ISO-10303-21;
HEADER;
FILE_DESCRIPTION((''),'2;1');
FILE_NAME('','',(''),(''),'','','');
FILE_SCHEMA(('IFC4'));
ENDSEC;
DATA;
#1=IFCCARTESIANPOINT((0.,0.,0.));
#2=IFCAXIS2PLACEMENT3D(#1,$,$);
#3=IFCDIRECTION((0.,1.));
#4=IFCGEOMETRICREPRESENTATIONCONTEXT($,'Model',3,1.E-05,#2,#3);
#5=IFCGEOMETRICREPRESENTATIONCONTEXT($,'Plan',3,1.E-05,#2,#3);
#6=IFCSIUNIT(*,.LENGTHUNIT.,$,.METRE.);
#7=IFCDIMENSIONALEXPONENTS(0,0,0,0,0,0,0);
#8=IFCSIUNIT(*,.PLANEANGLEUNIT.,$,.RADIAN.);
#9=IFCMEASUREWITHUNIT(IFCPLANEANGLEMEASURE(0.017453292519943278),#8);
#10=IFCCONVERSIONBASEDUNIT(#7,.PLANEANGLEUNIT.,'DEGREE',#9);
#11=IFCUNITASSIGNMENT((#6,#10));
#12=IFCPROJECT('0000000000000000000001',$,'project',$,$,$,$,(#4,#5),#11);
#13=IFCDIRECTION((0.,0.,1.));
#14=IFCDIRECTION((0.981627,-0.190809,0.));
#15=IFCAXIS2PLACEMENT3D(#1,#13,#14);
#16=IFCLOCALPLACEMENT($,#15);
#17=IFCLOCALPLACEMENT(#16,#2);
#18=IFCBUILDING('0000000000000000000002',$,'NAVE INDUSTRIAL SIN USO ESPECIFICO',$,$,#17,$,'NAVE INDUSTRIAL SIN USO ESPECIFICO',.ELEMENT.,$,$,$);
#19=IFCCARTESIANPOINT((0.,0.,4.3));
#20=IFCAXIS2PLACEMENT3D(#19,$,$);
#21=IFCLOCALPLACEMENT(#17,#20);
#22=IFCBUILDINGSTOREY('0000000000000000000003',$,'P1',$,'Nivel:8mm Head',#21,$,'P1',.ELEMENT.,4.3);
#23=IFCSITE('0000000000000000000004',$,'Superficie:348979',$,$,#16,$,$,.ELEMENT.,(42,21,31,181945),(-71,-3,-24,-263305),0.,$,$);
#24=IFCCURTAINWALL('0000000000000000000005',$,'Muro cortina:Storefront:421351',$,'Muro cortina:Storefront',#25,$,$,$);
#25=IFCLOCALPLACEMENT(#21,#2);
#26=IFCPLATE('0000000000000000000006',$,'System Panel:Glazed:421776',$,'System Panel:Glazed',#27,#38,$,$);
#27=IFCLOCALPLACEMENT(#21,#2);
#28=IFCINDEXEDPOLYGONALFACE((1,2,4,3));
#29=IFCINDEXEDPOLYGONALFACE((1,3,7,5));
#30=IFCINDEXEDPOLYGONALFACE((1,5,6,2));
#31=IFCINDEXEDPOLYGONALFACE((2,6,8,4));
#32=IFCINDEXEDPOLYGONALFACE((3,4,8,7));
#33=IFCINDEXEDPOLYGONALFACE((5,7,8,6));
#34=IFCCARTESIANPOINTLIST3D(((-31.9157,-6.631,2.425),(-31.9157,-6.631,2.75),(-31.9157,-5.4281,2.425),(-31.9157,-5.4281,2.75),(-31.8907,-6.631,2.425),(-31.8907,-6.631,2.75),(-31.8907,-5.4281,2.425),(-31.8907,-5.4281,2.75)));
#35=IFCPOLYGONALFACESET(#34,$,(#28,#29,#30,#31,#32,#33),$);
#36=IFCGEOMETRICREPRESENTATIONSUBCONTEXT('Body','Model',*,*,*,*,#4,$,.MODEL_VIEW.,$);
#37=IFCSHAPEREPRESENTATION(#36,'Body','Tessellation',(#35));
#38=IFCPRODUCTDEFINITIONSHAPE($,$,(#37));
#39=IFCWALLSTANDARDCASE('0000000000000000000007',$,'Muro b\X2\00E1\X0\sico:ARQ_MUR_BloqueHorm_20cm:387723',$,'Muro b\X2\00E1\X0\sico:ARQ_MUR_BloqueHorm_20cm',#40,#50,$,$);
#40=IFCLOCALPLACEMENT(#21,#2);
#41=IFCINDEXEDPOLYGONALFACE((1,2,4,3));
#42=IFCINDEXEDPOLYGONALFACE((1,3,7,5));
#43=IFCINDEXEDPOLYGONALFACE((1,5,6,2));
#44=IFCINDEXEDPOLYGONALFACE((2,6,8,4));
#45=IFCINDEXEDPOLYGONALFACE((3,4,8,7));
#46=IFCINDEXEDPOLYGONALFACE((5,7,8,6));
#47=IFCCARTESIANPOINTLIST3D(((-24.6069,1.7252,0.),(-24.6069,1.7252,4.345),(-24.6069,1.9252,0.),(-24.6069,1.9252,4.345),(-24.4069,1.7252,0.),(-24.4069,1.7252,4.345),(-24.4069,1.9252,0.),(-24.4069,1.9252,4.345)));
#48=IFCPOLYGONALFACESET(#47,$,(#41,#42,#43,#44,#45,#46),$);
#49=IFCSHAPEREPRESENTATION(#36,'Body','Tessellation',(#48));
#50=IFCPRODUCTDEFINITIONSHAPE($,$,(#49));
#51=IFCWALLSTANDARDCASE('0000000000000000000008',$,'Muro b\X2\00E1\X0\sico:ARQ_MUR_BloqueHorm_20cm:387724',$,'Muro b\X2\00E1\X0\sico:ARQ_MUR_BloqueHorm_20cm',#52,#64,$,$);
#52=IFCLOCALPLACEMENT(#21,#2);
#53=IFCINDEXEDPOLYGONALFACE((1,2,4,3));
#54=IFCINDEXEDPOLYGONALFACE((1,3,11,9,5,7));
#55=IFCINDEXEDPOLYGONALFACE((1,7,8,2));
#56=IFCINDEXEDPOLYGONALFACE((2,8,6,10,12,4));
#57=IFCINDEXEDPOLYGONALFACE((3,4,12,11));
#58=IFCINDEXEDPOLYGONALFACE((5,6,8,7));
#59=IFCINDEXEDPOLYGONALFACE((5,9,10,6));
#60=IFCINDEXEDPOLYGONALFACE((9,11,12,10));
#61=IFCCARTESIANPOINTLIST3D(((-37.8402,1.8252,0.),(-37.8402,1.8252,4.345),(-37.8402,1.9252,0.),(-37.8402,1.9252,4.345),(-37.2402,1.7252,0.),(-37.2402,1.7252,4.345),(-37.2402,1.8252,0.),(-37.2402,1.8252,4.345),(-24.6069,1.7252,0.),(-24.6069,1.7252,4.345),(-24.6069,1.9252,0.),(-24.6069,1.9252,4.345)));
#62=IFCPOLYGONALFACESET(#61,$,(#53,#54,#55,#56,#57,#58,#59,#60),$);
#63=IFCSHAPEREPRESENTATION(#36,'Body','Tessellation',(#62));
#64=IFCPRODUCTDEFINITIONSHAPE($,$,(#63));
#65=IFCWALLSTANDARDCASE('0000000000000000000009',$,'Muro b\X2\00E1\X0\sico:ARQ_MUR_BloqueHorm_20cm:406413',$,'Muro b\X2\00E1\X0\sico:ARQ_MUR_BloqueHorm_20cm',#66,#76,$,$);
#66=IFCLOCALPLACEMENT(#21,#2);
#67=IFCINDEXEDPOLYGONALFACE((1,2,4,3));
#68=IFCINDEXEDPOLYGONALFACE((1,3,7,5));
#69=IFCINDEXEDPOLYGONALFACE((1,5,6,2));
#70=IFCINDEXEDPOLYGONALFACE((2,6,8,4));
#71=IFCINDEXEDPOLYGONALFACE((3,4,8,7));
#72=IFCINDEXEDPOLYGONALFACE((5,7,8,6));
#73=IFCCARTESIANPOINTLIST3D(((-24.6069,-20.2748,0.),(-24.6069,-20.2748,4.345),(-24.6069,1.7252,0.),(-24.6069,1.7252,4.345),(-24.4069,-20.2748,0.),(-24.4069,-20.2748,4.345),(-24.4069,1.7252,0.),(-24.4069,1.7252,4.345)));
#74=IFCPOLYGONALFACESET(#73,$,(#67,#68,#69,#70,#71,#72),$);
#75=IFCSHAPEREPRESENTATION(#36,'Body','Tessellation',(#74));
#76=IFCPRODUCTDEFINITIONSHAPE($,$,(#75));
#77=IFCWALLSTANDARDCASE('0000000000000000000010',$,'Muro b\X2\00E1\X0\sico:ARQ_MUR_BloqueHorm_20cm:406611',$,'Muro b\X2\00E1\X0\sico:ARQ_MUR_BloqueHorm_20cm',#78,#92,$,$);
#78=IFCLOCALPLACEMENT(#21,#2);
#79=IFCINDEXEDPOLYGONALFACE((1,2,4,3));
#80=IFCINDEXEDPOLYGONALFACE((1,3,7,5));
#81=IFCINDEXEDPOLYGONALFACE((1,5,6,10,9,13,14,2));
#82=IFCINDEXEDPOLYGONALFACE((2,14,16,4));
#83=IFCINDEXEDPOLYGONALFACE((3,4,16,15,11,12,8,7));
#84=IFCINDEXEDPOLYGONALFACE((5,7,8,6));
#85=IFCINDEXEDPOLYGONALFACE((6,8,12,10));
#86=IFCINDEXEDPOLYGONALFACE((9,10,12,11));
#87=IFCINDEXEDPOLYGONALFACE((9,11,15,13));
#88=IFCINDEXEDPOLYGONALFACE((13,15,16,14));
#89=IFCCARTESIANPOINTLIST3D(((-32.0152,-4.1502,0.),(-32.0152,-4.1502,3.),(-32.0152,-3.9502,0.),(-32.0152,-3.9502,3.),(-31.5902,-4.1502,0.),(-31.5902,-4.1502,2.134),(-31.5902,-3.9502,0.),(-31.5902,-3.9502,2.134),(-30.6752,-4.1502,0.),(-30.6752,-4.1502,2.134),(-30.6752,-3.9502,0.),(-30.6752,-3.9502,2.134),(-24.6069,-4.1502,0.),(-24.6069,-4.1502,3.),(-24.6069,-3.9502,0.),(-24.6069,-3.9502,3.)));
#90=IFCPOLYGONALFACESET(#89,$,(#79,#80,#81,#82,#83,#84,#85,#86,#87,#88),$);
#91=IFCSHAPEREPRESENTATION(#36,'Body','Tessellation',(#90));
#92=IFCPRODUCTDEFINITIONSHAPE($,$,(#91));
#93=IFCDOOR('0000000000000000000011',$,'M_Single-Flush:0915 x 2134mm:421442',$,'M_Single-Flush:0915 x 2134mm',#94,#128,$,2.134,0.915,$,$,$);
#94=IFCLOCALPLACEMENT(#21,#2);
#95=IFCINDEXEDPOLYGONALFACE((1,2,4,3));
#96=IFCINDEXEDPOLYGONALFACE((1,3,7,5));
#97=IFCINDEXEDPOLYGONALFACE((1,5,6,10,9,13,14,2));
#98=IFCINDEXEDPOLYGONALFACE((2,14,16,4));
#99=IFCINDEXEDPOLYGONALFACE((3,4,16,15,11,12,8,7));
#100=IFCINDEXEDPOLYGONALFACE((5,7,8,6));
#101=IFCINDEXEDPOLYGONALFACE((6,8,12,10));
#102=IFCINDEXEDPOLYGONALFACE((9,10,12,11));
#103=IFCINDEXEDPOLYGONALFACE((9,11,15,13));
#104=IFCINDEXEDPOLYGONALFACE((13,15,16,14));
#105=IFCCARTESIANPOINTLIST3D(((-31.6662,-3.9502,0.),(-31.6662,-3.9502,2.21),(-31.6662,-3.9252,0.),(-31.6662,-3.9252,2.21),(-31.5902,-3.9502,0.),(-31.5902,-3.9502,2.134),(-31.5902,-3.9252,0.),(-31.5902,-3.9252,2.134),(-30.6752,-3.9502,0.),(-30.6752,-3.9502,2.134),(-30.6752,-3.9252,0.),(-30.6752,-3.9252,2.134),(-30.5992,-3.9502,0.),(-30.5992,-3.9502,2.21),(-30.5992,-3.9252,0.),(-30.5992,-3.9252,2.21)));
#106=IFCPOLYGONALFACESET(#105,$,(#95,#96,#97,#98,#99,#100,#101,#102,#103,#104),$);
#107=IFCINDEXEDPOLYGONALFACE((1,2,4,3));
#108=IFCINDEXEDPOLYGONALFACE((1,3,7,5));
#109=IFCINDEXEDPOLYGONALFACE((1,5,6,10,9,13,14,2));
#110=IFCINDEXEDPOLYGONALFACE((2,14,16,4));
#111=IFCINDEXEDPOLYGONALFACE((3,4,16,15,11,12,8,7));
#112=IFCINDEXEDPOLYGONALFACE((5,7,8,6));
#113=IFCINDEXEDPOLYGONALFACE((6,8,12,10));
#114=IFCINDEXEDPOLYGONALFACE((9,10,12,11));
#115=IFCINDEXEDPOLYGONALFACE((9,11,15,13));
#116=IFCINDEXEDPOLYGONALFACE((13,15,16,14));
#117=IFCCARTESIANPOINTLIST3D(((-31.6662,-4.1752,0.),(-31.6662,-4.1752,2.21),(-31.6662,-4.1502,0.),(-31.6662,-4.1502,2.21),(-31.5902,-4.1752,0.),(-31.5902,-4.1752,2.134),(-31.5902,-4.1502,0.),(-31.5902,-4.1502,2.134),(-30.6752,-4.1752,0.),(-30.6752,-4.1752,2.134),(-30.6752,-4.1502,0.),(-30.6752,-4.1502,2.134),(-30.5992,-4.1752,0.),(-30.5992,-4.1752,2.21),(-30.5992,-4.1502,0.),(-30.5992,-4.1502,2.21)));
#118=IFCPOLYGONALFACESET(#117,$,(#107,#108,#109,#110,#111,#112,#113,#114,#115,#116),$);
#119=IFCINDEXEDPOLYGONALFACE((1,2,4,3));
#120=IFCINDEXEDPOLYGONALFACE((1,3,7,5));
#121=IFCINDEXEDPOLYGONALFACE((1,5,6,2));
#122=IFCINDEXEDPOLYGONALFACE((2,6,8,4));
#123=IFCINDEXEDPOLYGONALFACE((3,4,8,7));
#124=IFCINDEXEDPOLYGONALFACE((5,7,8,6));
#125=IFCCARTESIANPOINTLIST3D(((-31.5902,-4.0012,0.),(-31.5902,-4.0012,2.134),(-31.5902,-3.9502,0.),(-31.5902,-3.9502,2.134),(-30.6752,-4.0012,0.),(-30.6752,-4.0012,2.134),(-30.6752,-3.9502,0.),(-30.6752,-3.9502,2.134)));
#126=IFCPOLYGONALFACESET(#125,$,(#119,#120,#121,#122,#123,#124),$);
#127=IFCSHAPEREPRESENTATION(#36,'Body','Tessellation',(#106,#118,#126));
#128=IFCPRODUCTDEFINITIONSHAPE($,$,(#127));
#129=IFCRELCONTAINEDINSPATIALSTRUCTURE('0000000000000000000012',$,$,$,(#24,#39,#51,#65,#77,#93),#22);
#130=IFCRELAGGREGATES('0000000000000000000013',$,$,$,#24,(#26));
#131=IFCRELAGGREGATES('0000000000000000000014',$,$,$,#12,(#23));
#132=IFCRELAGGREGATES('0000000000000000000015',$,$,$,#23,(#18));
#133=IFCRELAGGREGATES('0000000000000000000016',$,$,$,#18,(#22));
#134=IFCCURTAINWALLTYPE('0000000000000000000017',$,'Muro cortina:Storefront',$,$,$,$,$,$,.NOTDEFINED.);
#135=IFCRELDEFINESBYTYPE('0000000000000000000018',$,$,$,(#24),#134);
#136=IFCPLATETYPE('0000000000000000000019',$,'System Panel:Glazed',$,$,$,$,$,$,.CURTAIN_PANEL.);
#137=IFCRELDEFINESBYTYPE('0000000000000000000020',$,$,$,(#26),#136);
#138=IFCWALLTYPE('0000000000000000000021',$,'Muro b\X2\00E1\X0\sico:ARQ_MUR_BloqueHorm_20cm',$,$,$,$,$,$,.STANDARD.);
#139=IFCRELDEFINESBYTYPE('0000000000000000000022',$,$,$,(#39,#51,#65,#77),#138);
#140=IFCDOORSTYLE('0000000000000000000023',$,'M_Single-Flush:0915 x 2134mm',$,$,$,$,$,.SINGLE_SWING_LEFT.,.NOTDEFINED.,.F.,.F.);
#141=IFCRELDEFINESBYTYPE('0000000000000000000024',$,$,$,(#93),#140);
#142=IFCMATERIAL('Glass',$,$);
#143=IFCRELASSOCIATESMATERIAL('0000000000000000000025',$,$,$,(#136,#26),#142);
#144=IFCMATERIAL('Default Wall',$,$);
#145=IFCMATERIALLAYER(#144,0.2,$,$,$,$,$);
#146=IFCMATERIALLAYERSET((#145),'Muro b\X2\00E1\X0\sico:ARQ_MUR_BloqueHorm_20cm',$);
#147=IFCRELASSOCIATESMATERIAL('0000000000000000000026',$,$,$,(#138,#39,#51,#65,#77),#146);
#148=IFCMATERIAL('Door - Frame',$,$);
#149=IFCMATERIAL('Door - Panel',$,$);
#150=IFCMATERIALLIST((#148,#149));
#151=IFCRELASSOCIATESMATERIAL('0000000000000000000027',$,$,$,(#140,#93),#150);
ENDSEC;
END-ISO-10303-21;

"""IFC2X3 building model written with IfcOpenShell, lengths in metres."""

from ifc_helpers import new_model, entity, si_unit, converted_unit, direction, frame, frame_2d, origin, origin_2d_with_axis, place, context, subcontext, project, spatial, polyline, rectangle, outline, extrude, clip, bounded_halfspace, source, transform, mapped, material, material_list, layer, layer_set, layer_usage, type_object, type_shapes, element, fill, aggregate, save


model = new_model("IFC2X3")

# Units and contexts
model_context = context("Model", 3, precision=1e-05, world=origin(), true_north=direction((0.0, 1.0)))
plan_context = context("Plan", 3, precision=1e-05, world=origin(), true_north=direction((0.0, 1.0)))
body_context = subcontext(model_context, "Body", "Model", "MODEL_VIEW")
ifc_project = project(units=[si_unit("LENGTHUNIT", "METRE"), converted_unit("PLANEANGLEUNIT", "DEGREE", entity("IfcPlaneAngleMeasure", 0.017453292519943278), si_unit("PLANEANGLEUNIT", "RADIAN"), dimensions=[0, 0, 0, 0, 0, 0, 0])], contexts=[model_context, plan_context])

# Site, building, storey
site_placement = place(None, frame((0.0, 0.0, 0.0), z_axis=(0.0, 0.0, 1.0), x_axis=(0.981627, -0.190809, 0.0)))
site = spatial("IfcSite", under=ifc_project, at=site_placement, Name="Superficie:348979", CompositionType="ELEMENT", RefLatitude=(42, 21, 31, 181945), RefLongitude=(-71, -3, -24, -263305), RefElevation=0.0)
building_placement = place(site_placement, origin())
building = spatial("IfcBuilding", under=site, at=building_placement, Name="NAVE INDUSTRIAL SIN USO ESPECIFICO", LongName="NAVE INDUSTRIAL SIN USO ESPECIFICO", CompositionType="ELEMENT")
storey_placement = place(building_placement, frame((0.0, 0.0, 4.3)))
storey = spatial("IfcBuildingStorey", under=building, at=storey_placement, Name="P1", ObjectType="Nivel:8mm Head", LongName="P1", CompositionType="ELEMENT", Elevation=4.3)

# Curtain wall
curtain_wall_type = type_object("IfcCurtainWallType", Name="Muro cortina:Storefront", PredefinedType="NOTDEFINED")
curtain_wall_placement = place(storey_placement, frame((0.0, 0.0, -4.3)))
curtain_wall = element("IfcCurtainWall", 1, at=curtain_wall_placement, inside=storey, type_object=curtain_wall_type, Name="Muro cortina:Storefront:421351", ObjectType="Muro cortina:Storefront")

# Plate
ifc_material_1 = material(Name="Glass")
plate_type_1 = type_object("IfcPlateType", Name="System Panel:Glazed", PredefinedType="CURTAIN_PANEL", material=ifc_material_1)
shared_shape_1 = source(origin(), body_context, "Body", "SweptSolid", [
    extrude(rectangle(XDim=0.025, YDim=1.2029, at=origin_2d_with_axis()), frame((0.6014, 0.0125, 0.0), z_axis=(0.0, 0.0, 1.0), x_axis=(0.0, 1.0, 0.0)), (0.0, 0.0, 1.0), 0.325),
])
type_shapes(plate_type_1, [shared_shape_1])
plate_1_placement = place(curtain_wall_placement, frame((-31.9157, -5.4281, 6.725), z_axis=(0.0, 0.0, 1.0), x_axis=(0.0, -1.0, 0.0)))
plate_1 = element("IfcPlate", 2, at=plate_1_placement, type_object=plate_type_1, material=ifc_material_1, Name="System Panel:Glazed:421776", ObjectType="System Panel:Glazed", context=body_context, shape_type="MappedRepresentation", body=[
    mapped(shared_shape_1, transform((0.0, 0.0, 0.0), scale=1.0)),
])
aggregate(curtain_wall, [plate_1])

# Walls
ifc_material_2 = material(Name="Default Wall")
ifc_layer_1 = layer(ifc_material_2, 0.2)
ifc_layer_set_1 = layer_set([ifc_layer_1], Name="Muro básico:ARQ_MUR_BloqueHorm_20cm")
ifc_layer_usage_1 = layer_usage(ifc_layer_set_1, "AXIS2", "POSITIVE", -0.1)
wall_type_1 = type_object("IfcWallType", Name="Muro básico:ARQ_MUR_BloqueHorm_20cm", PredefinedType="STANDARD", material=ifc_layer_set_1)
wall_1_placement = place(storey_placement, frame((-24.5069, 1.7252, 0.0), z_axis=(0.0, 0.0, 1.0), x_axis=(0.0, 1.0, 0.0)))
element("IfcWallStandardCase", 3, at=wall_1_placement, inside=storey, type_object=wall_type_1, material=ifc_layer_usage_1, Name="Muro básico:ARQ_MUR_BloqueHorm_20cm:387723", ObjectType="Muro básico:ARQ_MUR_BloqueHorm_20cm", context=body_context, shape_type="Clipping", body=[
    clip(extrude(rectangle(XDim=0.2, YDim=0.2, at=frame_2d((0.1, 0.0), x_axis=(0.0, -1.0))), origin(), (0.0, 0.0, 1.0), 4.345), bounded_halfspace(frame((0.0, -0.1, 0.0), z_axis=(-1.0, 0.0, 0.0), x_axis=(0.0, -1.0, 0.0)), False, frame((0.0, -0.1, 0.0), z_axis=(-1.0, 0.0, 0.0), x_axis=(0.0, -1.0, 0.0)), polyline([(0.0, 0.0), (0.0, 4.345), (-0.2, 4.345), (-0.2, 0.0), (0.0, 0.0)]))),
])
ifc_layer_usage_2 = layer_usage(ifc_layer_set_1, "AXIS2", "POSITIVE", -0.1)
wall_2_placement = place(storey_placement, frame((-24.6069, 1.8252, 0.0), z_axis=(0.0, 0.0, 1.0), x_axis=(-1.0, 0.0, 0.0)))
element("IfcWallStandardCase", 4, at=wall_2_placement, inside=storey, type_object=wall_type_1, material=ifc_layer_usage_2, Name="Muro básico:ARQ_MUR_BloqueHorm_20cm:387724", ObjectType="Muro básico:ARQ_MUR_BloqueHorm_20cm", context=body_context, shape_type="Clipping", body=[
    clip(clip(extrude(rectangle(XDim=13.2333, YDim=0.2, at=frame_2d((6.6167, 0.0), x_axis=(-1.0, 0.0))), origin(), (0.0, 0.0, 1.0), 4.345), bounded_halfspace(frame((12.6333, 0.0, 0.0), z_axis=(0.0, -1.0, 0.0), x_axis=(0.0, 0.0, -1.0)), True, frame((12.6333, 0.0, 0.0), z_axis=(0.0, -1.0, 0.0), x_axis=(0.0, 0.0, -1.0)), polyline([(0.0, 0.0), (0.0, 0.6), (-4.345, 0.6), (-4.345, 0.0), (0.0, 0.0)]))), bounded_halfspace(frame((12.6333, 0.0, 4.345), z_axis=(-1.0, 0.0, 0.0), x_axis=(0.0, 0.0, -1.0)), True, frame((12.6333, 0.0, 4.345), z_axis=(-1.0, 0.0, 0.0), x_axis=(0.0, 0.0, -1.0)), polyline([(0.0, 0.0), (0.0, -0.1), (4.345, -0.1), (4.345, 0.0), (0.0, 0.0)]))),
])
ifc_layer_usage_3 = layer_usage(ifc_layer_set_1, "AXIS2", "POSITIVE", -0.1)
wall_3_placement = place(storey_placement, frame((-24.5069, -20.2748, 0.0), z_axis=(0.0, 0.0, 1.0), x_axis=(0.0, 1.0, 0.0)))
element("IfcWallStandardCase", 5, at=wall_3_placement, inside=storey, type_object=wall_type_1, material=ifc_layer_usage_3, Name="Muro básico:ARQ_MUR_BloqueHorm_20cm:406413", ObjectType="Muro básico:ARQ_MUR_BloqueHorm_20cm", context=body_context, shape_type="SweptSolid", body=[
    extrude(rectangle(XDim=22.0, YDim=0.2, at=frame_2d((11.0, 0.0), x_axis=(-1.0, 0.0))), origin(), (0.0, 0.0, 1.0), 4.345),
])

# Wall, opening, door
ifc_layer_usage_4 = layer_usage(ifc_layer_set_1, "AXIS2", "NEGATIVE", 0.1)
wall_4_placement = place(storey_placement, frame((-32.0152, -4.0502, 0.0)))
wall_4 = element("IfcWallStandardCase", 6, at=wall_4_placement, inside=storey, type_object=wall_type_1, material=ifc_layer_usage_4, Name="Muro básico:ARQ_MUR_BloqueHorm_20cm:406611", ObjectType="Muro básico:ARQ_MUR_BloqueHorm_20cm", context=body_context, shape_type="SweptSolid", body=[
    extrude(rectangle(XDim=7.4083, YDim=0.2, at=frame_2d((3.7042, 0.0), x_axis=(1.0, 0.0))), origin(), (0.0, 0.0, 1.0), 3.0),
])
opening_1_placement = place(wall_4_placement, frame((0.425, -0.1, 0.0)))
opening_1 = element("IfcOpeningElement", 7, at=opening_1_placement, cuts=wall_4, ObjectType="Opening", context=body_context, shape_type="SweptSolid", body=[
    extrude(rectangle(XDim=0.915, YDim=2.134, at=frame_2d((1.067, 0.4575), x_axis=(0.0, -1.0))), frame((0.0, 0.0, 0.0), z_axis=(0.0, 1.0, 0.0), x_axis=(0.0, 0.0, 1.0)), (0.0, 0.0, 1.0), 0.2),
])
ifc_material_3 = material(Name="Door - Frame")
ifc_material_4 = material(Name="Door - Panel")
ifc_material_list = material_list([ifc_material_3, ifc_material_4])
door_style_1 = type_object("IfcDoorStyle", Name="M_Single-Flush:0915 x 2134mm", ConstructionType="NOTDEFINED", OperationType="SINGLE_SWING_LEFT", ParameterTakesPrecedence=False, Sizeable=False, material=ifc_material_list)
shared_shape_2 = source(origin(), body_context, "Body", "SweptSolid", [
    extrude(outline(polyline([(-0.5335, -1.124), (0.5335, -1.124), (0.5335, 1.086), (0.4575, 1.086), (0.4575, -1.048), (-0.4575, -1.048), (-0.4575, 1.086), (-0.5335, 1.086), (-0.5335, -1.124)])), frame((0.4575, 0.225, 1.086), z_axis=(0.0, -1.0, 0.0), x_axis=(-1.0, 0.0, 0.0)), (0.0, 0.0, 1.0), 0.025),
    extrude(outline(polyline([(-1.124, -0.5335), (1.086, -0.5335), (1.086, -0.4575), (-1.048, -0.4575), (-1.048, 0.4575), (1.086, 0.4575), (1.086, 0.5335), (-1.124, 0.5335), (-1.124, -0.5335)])), frame((0.4575, 0.0, 1.086), z_axis=(0.0, -1.0, 0.0), x_axis=(0.0, 0.0, -1.0)), (0.0, 0.0, 1.0), 0.025),
    extrude(rectangle(XDim=0.915, YDim=0.051, at=frame_2d((0.0, 0.0), x_axis=(1.0, 0.0))), frame((0.4575, 0.1745, 0.0)), (0.0, 0.0, 1.0), 2.134),
])
type_shapes(door_style_1, [shared_shape_2])
door_1_placement = place(opening_1_placement, origin())
door_1 = element("IfcDoor", 8, at=door_1_placement, inside=storey, type_object=door_style_1, material=ifc_material_list, Name="M_Single-Flush:0915 x 2134mm:421442", ObjectType="M_Single-Flush:0915 x 2134mm", OverallHeight=2.134, OverallWidth=0.915, context=body_context, shape_type="MappedRepresentation", body=[
    mapped(shared_shape_2, transform((0.0, 0.0, 0.0), scale=1.0)),
])
fill(opening_1, door_1)

save(model, "model.ifc")
